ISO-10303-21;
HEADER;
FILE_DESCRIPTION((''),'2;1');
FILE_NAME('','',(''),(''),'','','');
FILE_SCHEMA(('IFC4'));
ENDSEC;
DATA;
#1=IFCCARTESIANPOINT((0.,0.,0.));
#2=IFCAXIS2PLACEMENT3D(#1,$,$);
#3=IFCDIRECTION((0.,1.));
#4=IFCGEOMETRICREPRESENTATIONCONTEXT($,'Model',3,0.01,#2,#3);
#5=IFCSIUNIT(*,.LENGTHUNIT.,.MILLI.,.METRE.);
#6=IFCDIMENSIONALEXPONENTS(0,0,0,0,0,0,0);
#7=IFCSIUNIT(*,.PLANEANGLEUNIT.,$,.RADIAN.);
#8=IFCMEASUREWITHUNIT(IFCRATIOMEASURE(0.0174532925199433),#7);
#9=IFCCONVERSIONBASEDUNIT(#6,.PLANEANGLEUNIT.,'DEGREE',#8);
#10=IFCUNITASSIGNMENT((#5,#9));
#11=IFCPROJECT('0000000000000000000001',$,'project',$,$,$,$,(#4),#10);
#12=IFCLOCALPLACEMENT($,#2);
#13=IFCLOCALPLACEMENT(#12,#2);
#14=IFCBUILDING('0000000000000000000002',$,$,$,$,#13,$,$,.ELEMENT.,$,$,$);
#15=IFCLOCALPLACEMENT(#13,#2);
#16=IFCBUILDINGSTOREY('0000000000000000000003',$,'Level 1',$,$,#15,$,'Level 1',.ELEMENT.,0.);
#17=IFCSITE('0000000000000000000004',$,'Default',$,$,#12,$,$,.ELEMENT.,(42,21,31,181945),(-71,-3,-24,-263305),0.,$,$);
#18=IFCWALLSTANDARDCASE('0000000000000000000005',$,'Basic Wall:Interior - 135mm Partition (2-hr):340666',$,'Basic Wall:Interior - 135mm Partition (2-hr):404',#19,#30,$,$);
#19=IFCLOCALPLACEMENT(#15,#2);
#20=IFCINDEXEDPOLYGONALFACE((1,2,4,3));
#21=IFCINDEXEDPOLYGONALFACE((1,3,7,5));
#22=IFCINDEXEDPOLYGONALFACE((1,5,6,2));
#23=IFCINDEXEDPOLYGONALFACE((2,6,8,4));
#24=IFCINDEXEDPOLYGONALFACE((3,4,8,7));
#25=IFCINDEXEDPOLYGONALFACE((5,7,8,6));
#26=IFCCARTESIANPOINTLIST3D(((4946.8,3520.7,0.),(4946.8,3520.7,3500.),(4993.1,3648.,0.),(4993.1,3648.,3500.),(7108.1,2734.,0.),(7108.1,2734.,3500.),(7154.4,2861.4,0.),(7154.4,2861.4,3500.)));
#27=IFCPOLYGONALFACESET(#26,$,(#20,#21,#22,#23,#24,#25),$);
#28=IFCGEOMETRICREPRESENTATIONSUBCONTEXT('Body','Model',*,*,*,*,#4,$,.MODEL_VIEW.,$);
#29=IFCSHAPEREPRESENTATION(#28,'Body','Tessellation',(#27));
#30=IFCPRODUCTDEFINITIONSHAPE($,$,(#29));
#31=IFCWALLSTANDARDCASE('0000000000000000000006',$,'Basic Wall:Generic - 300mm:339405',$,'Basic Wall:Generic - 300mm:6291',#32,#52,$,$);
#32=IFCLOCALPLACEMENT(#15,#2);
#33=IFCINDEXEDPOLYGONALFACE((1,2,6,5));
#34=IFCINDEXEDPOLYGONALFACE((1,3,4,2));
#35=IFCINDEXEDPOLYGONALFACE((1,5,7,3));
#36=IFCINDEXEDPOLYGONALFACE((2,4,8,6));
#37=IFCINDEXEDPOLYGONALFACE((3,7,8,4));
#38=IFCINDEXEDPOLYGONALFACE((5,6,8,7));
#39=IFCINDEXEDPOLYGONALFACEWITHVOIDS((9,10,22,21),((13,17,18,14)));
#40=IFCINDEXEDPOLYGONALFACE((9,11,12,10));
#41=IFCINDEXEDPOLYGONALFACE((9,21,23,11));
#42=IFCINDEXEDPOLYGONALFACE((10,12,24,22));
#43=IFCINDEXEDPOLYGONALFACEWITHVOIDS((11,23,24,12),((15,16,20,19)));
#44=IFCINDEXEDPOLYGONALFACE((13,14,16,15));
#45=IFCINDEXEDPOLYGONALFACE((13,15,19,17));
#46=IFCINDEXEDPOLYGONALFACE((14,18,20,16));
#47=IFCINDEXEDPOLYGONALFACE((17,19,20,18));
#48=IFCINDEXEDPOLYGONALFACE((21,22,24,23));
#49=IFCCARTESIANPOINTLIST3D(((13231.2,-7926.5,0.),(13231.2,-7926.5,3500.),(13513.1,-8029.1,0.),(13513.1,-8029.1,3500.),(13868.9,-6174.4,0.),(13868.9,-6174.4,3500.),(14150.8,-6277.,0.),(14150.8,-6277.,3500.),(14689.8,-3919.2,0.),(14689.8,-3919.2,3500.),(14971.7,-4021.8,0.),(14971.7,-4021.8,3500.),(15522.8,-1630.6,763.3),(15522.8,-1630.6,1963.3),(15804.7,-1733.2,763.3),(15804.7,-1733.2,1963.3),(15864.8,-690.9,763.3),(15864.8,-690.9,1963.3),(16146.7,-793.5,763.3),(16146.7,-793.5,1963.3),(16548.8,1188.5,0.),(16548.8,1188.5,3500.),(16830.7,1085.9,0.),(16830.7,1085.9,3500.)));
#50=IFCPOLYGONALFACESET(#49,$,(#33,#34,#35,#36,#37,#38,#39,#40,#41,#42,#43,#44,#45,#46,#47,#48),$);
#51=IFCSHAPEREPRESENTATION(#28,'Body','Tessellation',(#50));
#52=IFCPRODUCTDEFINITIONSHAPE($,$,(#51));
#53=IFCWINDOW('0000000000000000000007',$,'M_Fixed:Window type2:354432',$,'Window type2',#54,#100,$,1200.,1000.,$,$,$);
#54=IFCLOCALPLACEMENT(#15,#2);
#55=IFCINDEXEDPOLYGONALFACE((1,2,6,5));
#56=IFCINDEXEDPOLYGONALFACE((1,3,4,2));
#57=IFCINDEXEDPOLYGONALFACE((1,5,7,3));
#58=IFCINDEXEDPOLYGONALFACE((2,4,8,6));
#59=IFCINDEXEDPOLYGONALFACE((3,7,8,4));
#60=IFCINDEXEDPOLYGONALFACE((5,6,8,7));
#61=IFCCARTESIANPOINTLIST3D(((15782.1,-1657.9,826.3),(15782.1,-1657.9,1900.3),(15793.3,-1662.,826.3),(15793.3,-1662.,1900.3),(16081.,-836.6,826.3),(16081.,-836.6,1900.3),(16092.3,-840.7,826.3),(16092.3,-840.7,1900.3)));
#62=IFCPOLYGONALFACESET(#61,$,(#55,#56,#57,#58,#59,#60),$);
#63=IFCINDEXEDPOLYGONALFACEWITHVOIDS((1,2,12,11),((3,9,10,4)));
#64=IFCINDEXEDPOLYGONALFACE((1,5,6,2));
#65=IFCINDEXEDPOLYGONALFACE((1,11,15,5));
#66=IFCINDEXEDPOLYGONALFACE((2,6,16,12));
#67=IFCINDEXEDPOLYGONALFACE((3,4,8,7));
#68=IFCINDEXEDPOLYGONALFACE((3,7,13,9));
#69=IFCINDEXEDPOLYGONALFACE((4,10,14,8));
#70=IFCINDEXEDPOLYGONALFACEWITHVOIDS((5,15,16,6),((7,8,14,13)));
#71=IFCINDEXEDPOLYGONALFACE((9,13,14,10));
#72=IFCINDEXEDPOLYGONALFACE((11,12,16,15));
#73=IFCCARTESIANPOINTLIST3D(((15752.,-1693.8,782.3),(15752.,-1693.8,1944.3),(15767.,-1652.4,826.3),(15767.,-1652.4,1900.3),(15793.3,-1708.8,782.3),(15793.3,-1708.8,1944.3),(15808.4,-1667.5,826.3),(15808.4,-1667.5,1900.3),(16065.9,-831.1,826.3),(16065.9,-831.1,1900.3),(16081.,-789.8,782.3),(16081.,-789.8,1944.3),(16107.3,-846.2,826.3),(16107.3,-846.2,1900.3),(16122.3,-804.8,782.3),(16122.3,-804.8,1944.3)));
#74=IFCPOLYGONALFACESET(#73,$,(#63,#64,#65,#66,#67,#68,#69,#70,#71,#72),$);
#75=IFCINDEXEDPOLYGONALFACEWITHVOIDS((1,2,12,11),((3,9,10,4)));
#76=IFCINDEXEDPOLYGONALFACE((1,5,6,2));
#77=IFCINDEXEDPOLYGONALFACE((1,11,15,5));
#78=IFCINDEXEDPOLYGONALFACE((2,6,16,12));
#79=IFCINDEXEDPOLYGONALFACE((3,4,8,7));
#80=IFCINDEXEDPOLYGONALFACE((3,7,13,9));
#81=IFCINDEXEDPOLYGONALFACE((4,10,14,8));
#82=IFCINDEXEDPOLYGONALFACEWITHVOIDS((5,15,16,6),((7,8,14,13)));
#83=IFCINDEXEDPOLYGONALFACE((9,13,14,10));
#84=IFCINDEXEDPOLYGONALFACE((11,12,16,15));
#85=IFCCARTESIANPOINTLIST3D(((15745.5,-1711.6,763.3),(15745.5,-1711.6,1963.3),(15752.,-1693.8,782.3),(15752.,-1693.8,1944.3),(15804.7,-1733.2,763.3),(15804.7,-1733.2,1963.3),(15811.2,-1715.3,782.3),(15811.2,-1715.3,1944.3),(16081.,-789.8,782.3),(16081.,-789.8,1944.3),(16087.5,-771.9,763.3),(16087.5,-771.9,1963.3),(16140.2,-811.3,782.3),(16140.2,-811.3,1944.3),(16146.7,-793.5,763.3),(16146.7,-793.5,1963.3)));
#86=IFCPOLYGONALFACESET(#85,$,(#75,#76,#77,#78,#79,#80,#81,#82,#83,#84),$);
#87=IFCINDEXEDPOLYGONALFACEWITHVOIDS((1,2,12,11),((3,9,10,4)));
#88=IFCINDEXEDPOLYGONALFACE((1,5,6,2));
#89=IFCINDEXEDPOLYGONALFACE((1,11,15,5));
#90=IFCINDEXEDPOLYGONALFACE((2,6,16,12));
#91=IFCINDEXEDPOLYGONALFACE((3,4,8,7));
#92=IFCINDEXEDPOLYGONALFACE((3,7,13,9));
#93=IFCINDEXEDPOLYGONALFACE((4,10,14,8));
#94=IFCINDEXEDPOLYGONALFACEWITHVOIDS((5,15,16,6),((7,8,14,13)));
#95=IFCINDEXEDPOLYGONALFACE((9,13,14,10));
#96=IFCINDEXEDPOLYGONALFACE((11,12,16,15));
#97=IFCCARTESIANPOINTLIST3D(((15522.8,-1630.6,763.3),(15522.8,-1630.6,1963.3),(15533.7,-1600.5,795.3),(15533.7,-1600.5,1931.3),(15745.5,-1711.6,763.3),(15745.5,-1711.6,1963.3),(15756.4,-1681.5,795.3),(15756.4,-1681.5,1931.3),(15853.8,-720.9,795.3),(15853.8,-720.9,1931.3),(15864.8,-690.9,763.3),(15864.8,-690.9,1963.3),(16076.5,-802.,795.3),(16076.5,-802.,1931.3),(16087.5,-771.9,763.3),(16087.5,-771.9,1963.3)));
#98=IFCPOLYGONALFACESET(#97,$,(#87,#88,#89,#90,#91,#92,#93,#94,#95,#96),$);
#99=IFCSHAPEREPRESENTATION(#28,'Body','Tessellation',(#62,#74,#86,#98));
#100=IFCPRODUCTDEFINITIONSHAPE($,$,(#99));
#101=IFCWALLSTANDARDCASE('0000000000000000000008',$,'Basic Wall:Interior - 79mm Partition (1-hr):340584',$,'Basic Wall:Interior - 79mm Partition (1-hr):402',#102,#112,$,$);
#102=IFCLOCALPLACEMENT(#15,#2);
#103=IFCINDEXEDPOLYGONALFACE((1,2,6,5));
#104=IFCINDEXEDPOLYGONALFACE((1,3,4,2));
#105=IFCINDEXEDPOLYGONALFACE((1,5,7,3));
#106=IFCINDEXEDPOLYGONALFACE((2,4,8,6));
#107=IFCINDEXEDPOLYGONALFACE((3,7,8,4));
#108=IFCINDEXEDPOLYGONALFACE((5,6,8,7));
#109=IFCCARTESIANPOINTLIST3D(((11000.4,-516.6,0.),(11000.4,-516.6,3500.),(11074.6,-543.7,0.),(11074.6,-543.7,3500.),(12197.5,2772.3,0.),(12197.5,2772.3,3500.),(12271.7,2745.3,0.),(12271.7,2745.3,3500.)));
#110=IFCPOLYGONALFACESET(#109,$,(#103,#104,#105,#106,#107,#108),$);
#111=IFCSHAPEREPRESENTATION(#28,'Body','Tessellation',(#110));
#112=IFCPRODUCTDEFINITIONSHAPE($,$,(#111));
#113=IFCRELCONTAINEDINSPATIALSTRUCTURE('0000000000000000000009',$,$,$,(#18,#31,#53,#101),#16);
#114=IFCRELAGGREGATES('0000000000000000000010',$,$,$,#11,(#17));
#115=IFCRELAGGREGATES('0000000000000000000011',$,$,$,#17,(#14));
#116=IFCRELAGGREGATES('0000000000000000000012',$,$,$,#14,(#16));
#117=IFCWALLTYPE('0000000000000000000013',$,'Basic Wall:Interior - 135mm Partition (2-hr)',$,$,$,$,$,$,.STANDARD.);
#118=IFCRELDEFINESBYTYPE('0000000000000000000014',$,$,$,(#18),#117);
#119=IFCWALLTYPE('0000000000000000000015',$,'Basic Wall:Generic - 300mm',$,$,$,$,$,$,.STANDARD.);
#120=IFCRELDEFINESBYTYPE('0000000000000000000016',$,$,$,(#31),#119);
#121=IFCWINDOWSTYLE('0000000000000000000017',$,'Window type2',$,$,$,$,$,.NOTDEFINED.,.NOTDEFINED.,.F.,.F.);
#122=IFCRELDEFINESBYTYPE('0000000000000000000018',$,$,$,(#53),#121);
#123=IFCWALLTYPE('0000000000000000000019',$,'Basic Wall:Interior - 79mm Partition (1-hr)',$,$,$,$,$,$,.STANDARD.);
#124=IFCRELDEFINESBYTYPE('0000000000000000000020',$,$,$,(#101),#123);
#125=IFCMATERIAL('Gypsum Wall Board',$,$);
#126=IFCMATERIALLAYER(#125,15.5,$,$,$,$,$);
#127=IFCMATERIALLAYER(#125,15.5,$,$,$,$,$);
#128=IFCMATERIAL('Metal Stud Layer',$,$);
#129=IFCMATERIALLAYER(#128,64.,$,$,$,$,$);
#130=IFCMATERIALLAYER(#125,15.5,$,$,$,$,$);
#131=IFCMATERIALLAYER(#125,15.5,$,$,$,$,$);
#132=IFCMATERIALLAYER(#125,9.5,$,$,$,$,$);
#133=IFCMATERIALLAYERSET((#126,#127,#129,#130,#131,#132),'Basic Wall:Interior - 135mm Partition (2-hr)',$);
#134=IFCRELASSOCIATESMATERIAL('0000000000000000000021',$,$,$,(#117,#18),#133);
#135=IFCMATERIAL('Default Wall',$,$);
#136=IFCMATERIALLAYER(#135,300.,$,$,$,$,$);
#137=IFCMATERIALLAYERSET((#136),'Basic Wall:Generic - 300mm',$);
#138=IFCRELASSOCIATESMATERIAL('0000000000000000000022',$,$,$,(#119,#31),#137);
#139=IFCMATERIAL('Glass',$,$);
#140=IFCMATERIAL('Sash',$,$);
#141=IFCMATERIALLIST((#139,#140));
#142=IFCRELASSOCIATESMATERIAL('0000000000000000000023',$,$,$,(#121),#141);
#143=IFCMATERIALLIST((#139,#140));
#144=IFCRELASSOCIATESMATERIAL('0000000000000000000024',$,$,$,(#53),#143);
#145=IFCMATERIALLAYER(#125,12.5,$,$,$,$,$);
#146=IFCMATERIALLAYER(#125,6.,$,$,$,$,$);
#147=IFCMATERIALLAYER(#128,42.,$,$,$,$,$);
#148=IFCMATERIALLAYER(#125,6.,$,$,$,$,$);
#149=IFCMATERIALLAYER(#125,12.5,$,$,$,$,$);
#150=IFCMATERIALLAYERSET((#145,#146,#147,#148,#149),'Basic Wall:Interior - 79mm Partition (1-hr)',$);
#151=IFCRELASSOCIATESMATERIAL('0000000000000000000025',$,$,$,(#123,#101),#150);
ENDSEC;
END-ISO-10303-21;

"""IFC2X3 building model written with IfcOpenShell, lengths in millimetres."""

from ifc_helpers import new_model, entity, si_unit, converted_unit, direction, frame, frame_2d, origin, place, context, subcontext, project, spatial, polyline, rectangle, outline, extrude, source, transform, mapped, material, material_list, layer, layer_set, layer_usage, type_object, type_shapes, element, fill, save


model = new_model("IFC2X3")

# Units and contexts
model_context = context("Model", 3, precision=0.01, world=origin(), true_north=direction((0.0, 1.0)))
body_context = subcontext(model_context, "Body", "Model", "MODEL_VIEW")
ifc_project = project(units=[si_unit("LENGTHUNIT", "METRE", prefix="MILLI"), converted_unit("PLANEANGLEUNIT", "DEGREE", entity("IfcRatioMeasure", 0.0174532925199433), si_unit("PLANEANGLEUNIT", "RADIAN"), dimensions=[0, 0, 0, 0, 0, 0, 0])], contexts=[model_context])

# Site, building, storey
site_placement = place(None, origin())
site = spatial("IfcSite", under=ifc_project, at=site_placement, Name="Default", CompositionType="ELEMENT", RefLatitude=(42, 21, 31, 181945), RefLongitude=(-71, -3, -24, -263305), RefElevation=0.0)
building_placement = place(site_placement, origin())
building = spatial("IfcBuilding", under=site, at=building_placement, CompositionType="ELEMENT")
storey_placement = place(building_placement, origin())
storey = spatial("IfcBuildingStorey", under=building, at=storey_placement, Name="Level 1", LongName="Level 1", CompositionType="ELEMENT", Elevation=0.0)

# Shared definitions
ifc_material_1 = material(Name="Gypsum Wall Board")
ifc_layer_1 = layer(ifc_material_1, 15.5)
ifc_layer_2 = layer(ifc_material_1, 15.5)
ifc_material_2 = material(Name="Metal Stud Layer")
ifc_layer_3 = layer(ifc_material_2, 64.0)
ifc_layer_4 = layer(ifc_material_1, 15.5)
ifc_layer_5 = layer(ifc_material_1, 15.5)
ifc_layer_6 = layer(ifc_material_1, 9.5)
ifc_layer_set_1 = layer_set([ifc_layer_1, ifc_layer_2, ifc_layer_3, ifc_layer_4, ifc_layer_5, ifc_layer_6], Name="Basic Wall:Interior - 135mm Partition (2-hr)")
wall_type_1 = type_object("IfcWallType", Name="Basic Wall:Interior - 135mm Partition (2-hr)", PredefinedType="STANDARD", material=ifc_layer_set_1)

# Wall
ifc_layer_usage_1 = layer_usage(ifc_layer_set_1, "AXIS2", "NEGATIVE", 67.8)
wall_1_placement = place(storey_placement, frame((7131.2, 2797.7, 0.0), z_axis=(0.0, 0.0, 1.0), x_axis=(-0.939693, 0.34202, 0.0)))
element("IfcWallStandardCase", 1, at=wall_1_placement, inside=storey, type_object=wall_type_1, material=ifc_layer_usage_1, Name="Basic Wall:Interior - 135mm Partition (2-hr):340666", ObjectType="Basic Wall:Interior - 135mm Partition (2-hr):404", context=body_context, shape_type="SweptSolid", body=[
    extrude(rectangle(XDim=2300.0, YDim=135.5, at=frame_2d((1150.0, 0.0), x_axis=(-1.0, 0.0))), origin(), (0.0, 0.0, 1.0), 3500.0),
])

# Shared definitions
ifc_material_3 = material(Name="Default Wall")
ifc_layer_7 = layer(ifc_material_3, 300.0)
ifc_layer_set_2 = layer_set([ifc_layer_7], Name="Basic Wall:Generic - 300mm")
wall_type_2 = type_object("IfcWallType", Name="Basic Wall:Generic - 300mm", PredefinedType="STANDARD", material=ifc_layer_set_2)
ifc_material_4 = material(Name="Glass")
ifc_material_5 = material(Name="Sash")
ifc_material_list_1 = material_list([ifc_material_4, ifc_material_5])
window_style_1 = type_object("IfcWindowStyle", Name="Window type2", ConstructionType="NOTDEFINED", OperationType="NOTDEFINED", ParameterTakesPrecedence=False, Sizeable=False, material=ifc_material_list_1)
shared_shape_1 = source(origin(), body_context, "Body", "SweptSolid", [
    extrude(rectangle(XDim=12.0, YDim=874.0, at=frame_2d((0.0, 0.0), x_axis=(1.0, 0.0))), frame((500.0, 259.0, 63.0), z_axis=(0.0, 0.0, 1.0), x_axis=(0.0, -1.0, 0.0)), (0.0, 0.0, 1.0), 1074.0),
    extrude(outline(polyline([(-481.0, -581.0), (481.0, -581.0), (481.0, 581.0), (-481.0, 581.0), (-481.0, -581.0)]), holes=[polyline([(-437.0, -537.0), (-437.0, 537.0), (437.0, 537.0), (437.0, -537.0), (-437.0, -537.0)])]), frame((500.0, 237.0, 600.0), z_axis=(0.0, 1.0, 0.0), x_axis=(1.0, 0.0, 0.0)), (0.0, 0.0, 1.0), 44.0),
    extrude(outline(polyline([(-500.0, -600.0), (500.0, -600.0), (500.0, 600.0), (-500.0, 600.0), (-500.0, -600.0)]), holes=[polyline([(-481.0, -581.0), (-481.0, 581.0), (481.0, 581.0), (481.0, -581.0), (-481.0, -581.0)])]), frame((500.0, 237.0, 600.0), z_axis=(0.0, 1.0, 0.0), x_axis=(1.0, 0.0, 0.0)), (0.0, 0.0, 1.0), 63.0),
    extrude(outline(polyline([(-500.0, -600.0), (500.0, -600.0), (500.0, 600.0), (-500.0, 600.0), (-500.0, -600.0)]), holes=[polyline([(-468.0, -568.0), (-468.0, 568.0), (468.0, 568.0), (468.0, -568.0), (-468.0, -568.0)])]), frame((500.0, 0.0, 600.0), z_axis=(0.0, 1.0, 0.0), x_axis=(1.0, 0.0, 0.0)), (0.0, 0.0, 1.0), 237.0),
])
type_shapes(window_style_1, [shared_shape_1])

# Wall, openings, window
ifc_layer_usage_2 = layer_usage(ifc_layer_set_2, "AXIS2", "NEGATIVE", 150.0)
wall_2_placement = place(storey_placement, frame((16689.8, 1137.2, 0.0), z_axis=(0.0, 0.0, 1.0), x_axis=(-0.34202, -0.939693, 0.0)))
wall_2 = element("IfcWallStandardCase", 2, at=wall_2_placement, inside=storey, type_object=wall_type_2, material=ifc_layer_usage_2, Name="Basic Wall:Generic - 300mm:339405", ObjectType="Basic Wall:Generic - 300mm:6291", context=body_context, shape_type="SweptSolid", body=[
    extrude(rectangle(XDim=9700.0, YDim=300.0, at=frame_2d((4850.0, 0.0), x_axis=(-1.0, 0.0))), origin(), (0.0, 0.0, 1.0), 3500.0),
])
opening_1_placement = place(wall_2_placement, origin())
element("IfcOpeningElement", 3, at=opening_1_placement, cuts=wall_2, ObjectType="Opening", context=body_context, shape_type="SweptSolid", body=[
    extrude(rectangle(XDim=3500.0, YDim=2400.0, at=frame_2d((0.0, 0.0), x_axis=(0.0, 1.0))), frame((6635.5, -302.4, 1750.0), z_axis=(0.0, 1.0, 0.0), x_axis=(-1.0, 0.0, 0.0)), (0.0, 0.0, 1.0), 604.8),
])
opening_2_placement = place(wall_2_placement, frame((2000.0, -150.0, 763.3)))
opening_2 = element("IfcOpeningElement", 4, at=opening_2_placement, cuts=wall_2, ObjectType="Opening", context=body_context, shape_type="SweptSolid", body=[
    extrude(rectangle(XDim=1200.0, YDim=1000.0, at=frame_2d((600.0, 500.0), x_axis=(1.0, 0.0))), frame((0.0, 0.0, 0.0), z_axis=(0.0, 1.0, 0.0), x_axis=(0.0, 0.0, 1.0)), (0.0, 0.0, 1.0), 300.0),
])
ifc_material_list_2 = material_list([ifc_material_4, ifc_material_5])
window_1_placement = place(opening_2_placement, origin())
window_1 = element("IfcWindow", 5, at=window_1_placement, inside=storey, type_object=window_style_1, material=ifc_material_list_2, Name="M_Fixed:Window type2:354432", ObjectType="Window type2", OverallHeight=1200.0, OverallWidth=1000.0, context=body_context, shape_type="MappedRepresentation", body=[
    mapped(shared_shape_1, transform((0.0, 0.0, 0.0), scale=1.0)),
])
fill(opening_2, window_1)

# Wall
ifc_layer_8 = layer(ifc_material_1, 12.5)
ifc_layer_9 = layer(ifc_material_1, 6.0)
ifc_layer_10 = layer(ifc_material_2, 42.0)
ifc_layer_11 = layer(ifc_material_1, 6.0)
ifc_layer_12 = layer(ifc_material_1, 12.5)
ifc_layer_set_3 = layer_set([ifc_layer_8, ifc_layer_9, ifc_layer_10, ifc_layer_11, ifc_layer_12], Name="Basic Wall:Interior - 79mm Partition (1-hr)")
ifc_layer_usage_3 = layer_usage(ifc_layer_set_3, "AXIS2", "NEGATIVE", 39.5)
wall_type_3 = type_object("IfcWallType", Name="Basic Wall:Interior - 79mm Partition (1-hr)", PredefinedType="STANDARD", material=ifc_layer_set_3)
wall_3_placement = place(storey_placement, frame((11037.5, -530.1, 0.0), z_axis=(0.0, 0.0, 1.0), x_axis=(0.34202, 0.939693, 0.0)))
element("IfcWallStandardCase", 6, at=wall_3_placement, inside=storey, type_object=wall_type_3, material=ifc_layer_usage_3, Name="Basic Wall:Interior - 79mm Partition (1-hr):340584", ObjectType="Basic Wall:Interior - 79mm Partition (1-hr):402", context=body_context, shape_type="SweptSolid", body=[
    extrude(rectangle(XDim=3500.0, YDim=79.0, at=frame_2d((1750.0, 0.0), x_axis=(-1.0, 0.0))), origin(), (0.0, 0.0, 1.0), 3500.0),
])

save(model, "model.ifc")
